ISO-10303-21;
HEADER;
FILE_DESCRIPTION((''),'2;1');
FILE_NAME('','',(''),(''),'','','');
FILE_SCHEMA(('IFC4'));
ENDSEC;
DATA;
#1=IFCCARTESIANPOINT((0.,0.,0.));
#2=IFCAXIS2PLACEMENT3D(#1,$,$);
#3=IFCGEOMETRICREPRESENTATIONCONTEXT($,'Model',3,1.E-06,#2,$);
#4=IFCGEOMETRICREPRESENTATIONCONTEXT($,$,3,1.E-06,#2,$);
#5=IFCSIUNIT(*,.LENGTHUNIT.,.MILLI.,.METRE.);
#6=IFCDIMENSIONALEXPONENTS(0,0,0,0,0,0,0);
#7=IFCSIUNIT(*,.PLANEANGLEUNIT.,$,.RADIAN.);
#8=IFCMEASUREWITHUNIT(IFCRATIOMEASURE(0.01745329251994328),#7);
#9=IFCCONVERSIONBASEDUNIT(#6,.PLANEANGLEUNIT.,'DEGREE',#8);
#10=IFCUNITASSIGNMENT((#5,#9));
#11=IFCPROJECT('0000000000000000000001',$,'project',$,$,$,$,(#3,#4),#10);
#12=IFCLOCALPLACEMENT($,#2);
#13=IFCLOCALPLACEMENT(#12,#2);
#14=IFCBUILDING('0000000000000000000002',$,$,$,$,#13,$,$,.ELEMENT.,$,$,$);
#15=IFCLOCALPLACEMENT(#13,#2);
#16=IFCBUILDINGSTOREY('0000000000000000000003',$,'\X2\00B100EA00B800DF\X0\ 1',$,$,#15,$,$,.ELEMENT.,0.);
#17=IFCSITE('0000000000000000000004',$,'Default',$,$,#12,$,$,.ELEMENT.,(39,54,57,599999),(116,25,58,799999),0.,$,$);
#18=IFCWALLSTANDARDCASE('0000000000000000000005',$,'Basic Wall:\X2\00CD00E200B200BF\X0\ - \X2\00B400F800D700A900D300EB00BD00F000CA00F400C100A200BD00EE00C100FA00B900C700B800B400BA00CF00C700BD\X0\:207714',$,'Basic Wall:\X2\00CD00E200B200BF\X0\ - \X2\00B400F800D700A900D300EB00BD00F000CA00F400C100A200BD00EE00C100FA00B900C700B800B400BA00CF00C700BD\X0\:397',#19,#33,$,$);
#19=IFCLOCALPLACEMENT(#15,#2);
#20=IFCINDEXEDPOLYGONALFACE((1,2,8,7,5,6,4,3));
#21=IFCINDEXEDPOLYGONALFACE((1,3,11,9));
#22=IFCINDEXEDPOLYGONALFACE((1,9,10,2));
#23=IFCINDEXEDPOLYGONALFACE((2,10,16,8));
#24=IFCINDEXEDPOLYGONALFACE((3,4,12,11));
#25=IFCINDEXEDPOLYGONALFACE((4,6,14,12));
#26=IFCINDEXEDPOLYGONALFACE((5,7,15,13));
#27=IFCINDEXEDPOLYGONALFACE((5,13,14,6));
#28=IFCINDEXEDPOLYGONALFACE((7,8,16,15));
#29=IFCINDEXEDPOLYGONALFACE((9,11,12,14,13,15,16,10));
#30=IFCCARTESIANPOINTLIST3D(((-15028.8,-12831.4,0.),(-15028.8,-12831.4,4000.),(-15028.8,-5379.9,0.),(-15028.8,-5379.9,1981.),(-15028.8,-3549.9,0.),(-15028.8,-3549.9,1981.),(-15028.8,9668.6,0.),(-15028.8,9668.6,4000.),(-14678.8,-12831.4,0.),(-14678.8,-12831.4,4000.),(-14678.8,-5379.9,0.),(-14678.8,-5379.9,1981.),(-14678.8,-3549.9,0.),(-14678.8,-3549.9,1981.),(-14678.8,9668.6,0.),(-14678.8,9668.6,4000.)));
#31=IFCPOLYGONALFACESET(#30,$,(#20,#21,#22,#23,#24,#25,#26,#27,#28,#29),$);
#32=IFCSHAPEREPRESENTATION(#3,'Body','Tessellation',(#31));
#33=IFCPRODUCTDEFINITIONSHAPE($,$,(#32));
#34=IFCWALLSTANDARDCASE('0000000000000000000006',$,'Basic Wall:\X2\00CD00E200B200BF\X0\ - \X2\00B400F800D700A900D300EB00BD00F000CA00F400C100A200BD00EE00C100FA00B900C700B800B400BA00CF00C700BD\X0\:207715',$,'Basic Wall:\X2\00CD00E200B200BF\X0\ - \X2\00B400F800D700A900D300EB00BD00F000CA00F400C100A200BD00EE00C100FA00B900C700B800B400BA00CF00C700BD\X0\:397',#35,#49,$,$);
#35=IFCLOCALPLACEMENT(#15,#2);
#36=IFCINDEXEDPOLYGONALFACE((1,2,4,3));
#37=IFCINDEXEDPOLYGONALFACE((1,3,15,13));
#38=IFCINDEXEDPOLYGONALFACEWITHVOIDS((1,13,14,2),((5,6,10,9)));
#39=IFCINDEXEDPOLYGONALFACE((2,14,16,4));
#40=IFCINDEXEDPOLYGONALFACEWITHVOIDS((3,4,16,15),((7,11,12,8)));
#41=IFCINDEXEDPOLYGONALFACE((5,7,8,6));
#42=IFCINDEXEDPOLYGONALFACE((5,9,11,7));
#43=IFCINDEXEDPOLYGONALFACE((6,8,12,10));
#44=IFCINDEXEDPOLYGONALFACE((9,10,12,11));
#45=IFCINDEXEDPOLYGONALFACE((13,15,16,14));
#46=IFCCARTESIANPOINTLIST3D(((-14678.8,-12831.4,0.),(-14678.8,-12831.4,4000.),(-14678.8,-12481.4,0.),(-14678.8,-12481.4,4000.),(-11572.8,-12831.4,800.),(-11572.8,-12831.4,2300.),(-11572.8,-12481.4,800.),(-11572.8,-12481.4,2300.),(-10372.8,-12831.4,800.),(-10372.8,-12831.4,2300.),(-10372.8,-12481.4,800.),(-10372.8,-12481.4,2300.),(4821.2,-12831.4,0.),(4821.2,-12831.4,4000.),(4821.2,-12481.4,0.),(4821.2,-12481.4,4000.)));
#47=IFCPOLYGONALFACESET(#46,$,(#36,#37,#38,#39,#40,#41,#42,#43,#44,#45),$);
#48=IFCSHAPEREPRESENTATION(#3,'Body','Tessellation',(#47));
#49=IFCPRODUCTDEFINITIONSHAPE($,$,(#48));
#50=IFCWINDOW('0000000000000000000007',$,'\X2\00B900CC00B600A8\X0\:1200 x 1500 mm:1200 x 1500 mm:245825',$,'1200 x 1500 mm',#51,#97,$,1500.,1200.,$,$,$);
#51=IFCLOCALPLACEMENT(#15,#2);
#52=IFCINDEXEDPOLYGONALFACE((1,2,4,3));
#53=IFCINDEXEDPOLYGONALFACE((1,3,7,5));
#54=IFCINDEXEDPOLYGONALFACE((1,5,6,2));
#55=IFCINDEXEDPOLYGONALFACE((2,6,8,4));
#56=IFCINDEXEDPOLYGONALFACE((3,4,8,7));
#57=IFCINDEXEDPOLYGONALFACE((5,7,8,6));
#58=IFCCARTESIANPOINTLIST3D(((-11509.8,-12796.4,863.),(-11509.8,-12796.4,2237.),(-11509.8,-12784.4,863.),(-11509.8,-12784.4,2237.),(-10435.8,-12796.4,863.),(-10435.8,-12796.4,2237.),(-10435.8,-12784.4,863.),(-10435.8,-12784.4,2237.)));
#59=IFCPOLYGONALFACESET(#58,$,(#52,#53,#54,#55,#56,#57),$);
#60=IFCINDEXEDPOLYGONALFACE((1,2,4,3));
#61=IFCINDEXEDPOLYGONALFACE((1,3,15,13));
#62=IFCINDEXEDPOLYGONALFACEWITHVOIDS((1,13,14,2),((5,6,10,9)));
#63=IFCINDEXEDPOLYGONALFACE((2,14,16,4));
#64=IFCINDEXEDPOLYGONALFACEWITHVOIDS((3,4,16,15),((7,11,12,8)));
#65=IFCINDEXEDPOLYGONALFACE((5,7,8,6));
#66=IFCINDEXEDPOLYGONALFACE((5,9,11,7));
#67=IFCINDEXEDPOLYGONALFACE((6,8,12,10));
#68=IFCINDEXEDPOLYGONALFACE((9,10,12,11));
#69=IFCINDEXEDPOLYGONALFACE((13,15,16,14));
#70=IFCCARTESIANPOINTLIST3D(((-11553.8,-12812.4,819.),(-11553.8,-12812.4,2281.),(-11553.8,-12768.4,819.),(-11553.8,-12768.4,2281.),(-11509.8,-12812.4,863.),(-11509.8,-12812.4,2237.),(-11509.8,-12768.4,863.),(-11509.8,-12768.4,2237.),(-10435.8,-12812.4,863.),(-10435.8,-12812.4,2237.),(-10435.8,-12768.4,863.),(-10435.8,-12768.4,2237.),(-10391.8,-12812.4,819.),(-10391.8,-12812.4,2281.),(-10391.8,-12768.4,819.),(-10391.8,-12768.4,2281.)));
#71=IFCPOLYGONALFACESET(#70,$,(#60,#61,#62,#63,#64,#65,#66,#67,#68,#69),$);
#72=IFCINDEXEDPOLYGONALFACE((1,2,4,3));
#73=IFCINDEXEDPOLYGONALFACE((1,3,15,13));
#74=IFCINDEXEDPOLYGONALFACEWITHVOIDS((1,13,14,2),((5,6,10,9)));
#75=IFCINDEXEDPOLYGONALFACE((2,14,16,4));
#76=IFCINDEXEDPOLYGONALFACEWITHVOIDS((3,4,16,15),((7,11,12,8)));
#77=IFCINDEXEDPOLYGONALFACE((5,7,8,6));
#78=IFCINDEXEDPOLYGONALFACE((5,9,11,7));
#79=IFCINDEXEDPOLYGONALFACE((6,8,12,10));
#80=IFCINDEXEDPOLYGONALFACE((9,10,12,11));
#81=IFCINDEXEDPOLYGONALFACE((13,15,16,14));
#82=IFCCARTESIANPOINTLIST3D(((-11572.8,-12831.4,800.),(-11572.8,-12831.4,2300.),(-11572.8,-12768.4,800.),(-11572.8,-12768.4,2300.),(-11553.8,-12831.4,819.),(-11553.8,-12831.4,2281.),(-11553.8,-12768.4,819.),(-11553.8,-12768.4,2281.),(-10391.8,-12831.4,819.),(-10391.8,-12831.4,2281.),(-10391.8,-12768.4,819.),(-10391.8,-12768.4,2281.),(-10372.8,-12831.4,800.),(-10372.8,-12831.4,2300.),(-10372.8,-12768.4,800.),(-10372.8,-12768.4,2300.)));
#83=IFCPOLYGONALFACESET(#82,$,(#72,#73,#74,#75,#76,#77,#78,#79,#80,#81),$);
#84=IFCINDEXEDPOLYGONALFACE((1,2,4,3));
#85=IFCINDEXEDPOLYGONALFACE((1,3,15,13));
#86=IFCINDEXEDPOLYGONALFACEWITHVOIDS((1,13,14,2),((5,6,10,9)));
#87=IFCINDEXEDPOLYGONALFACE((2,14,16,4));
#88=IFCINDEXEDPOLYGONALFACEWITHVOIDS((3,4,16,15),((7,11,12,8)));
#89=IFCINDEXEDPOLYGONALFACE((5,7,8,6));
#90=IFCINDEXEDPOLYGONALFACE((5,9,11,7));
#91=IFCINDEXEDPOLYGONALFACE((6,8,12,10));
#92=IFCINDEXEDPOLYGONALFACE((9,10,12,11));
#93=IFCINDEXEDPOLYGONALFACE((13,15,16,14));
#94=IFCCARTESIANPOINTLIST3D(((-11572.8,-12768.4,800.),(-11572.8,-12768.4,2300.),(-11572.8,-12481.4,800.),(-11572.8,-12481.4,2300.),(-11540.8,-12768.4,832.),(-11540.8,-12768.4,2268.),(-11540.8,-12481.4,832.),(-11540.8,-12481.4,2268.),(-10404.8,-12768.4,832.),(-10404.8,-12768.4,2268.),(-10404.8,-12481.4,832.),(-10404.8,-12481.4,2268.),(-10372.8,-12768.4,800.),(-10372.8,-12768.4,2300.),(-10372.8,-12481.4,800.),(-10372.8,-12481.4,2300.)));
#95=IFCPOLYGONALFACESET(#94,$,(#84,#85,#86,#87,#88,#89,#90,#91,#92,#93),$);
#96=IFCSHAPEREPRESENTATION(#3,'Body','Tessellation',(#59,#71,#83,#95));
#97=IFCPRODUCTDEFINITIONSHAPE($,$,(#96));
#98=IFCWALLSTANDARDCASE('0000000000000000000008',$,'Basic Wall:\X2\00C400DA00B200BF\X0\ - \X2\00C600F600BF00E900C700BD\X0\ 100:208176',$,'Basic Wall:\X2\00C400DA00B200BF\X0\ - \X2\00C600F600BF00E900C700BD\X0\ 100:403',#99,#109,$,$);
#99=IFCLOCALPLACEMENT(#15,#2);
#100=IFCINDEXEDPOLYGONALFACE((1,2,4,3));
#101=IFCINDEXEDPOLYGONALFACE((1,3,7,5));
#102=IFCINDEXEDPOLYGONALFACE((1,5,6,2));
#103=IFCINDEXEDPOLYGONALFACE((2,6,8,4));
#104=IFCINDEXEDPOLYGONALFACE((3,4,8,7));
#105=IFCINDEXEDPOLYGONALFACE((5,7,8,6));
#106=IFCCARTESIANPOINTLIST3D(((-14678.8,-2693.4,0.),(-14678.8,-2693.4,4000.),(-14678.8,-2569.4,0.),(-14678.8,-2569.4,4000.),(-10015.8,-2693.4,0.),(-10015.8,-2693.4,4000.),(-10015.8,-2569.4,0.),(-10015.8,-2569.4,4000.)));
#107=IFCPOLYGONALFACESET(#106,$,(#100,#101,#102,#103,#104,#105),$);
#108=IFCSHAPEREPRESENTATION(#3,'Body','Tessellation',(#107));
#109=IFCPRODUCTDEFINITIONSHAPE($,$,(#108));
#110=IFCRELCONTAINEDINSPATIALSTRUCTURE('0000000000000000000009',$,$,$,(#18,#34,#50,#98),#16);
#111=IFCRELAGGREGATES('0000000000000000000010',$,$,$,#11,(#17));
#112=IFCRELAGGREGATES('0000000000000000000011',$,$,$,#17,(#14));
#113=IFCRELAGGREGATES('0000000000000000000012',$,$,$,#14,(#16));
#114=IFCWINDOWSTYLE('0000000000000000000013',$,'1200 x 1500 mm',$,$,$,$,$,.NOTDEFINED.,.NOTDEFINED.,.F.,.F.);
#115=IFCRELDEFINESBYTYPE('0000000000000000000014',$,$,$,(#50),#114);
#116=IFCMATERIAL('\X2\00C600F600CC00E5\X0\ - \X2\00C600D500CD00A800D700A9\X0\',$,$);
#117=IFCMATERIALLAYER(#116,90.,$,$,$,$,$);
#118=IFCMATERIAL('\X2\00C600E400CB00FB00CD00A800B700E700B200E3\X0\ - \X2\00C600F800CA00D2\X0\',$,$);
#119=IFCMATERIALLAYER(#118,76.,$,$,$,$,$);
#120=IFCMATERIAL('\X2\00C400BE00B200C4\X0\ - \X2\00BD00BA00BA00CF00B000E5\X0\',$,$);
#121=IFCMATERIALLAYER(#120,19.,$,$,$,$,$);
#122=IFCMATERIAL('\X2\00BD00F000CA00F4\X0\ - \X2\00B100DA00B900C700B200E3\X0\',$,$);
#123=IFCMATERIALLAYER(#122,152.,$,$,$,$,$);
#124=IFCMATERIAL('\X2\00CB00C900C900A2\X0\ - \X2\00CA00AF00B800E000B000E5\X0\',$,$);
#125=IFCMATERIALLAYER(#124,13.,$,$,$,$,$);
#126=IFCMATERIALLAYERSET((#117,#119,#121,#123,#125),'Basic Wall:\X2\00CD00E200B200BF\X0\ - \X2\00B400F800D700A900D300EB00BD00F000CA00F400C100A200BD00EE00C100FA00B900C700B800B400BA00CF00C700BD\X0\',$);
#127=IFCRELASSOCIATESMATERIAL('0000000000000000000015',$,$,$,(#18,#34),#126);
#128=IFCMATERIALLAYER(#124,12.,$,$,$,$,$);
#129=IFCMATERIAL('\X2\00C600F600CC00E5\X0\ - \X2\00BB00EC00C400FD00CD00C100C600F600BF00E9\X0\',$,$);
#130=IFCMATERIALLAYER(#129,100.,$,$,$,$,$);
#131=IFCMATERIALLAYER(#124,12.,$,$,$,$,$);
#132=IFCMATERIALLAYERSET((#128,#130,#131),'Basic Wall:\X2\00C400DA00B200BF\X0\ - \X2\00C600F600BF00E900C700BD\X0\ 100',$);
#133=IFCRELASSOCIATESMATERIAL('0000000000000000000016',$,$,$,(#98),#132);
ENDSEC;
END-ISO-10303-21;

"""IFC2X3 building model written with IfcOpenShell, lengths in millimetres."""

from ifc_helpers import new_model, entity, si_unit, converted_unit, frame, frame_2d, origin, origin_2d_with_axis, place, context, project, spatial, polyline, rectangle, outline, extrude, source, transform, mapped, material, layer, layer_set, layer_usage, type_object, type_shapes, element, fill, save


model = new_model("IFC2X3")

# Units and contexts
model_context = context("Model", 3, precision=1e-06, world=origin())
context_of_model = context(None, 3, precision=1e-06, world=origin())
ifc_project = project(units=[si_unit("LENGTHUNIT", "METRE", prefix="MILLI"), converted_unit("PLANEANGLEUNIT", "DEGREE", entity("IfcRatioMeasure", 0.01745329251994328), si_unit("PLANEANGLEUNIT", "RADIAN"), dimensions=[0, 0, 0, 0, 0, 0, 0])], contexts=[model_context, context_of_model])

# Site, building, storey
site_placement = place(None, origin())
site = spatial("IfcSite", under=ifc_project, at=site_placement, Name="Default", CompositionType="ELEMENT", RefLatitude=(39, 54, 57, 599999), RefLongitude=(116, 25, 58, 799999), RefElevation=0.0)
building_placement = place(site_placement, origin())
building = spatial("IfcBuilding", under=site, at=building_placement, CompositionType="ELEMENT")
storey_placement = place(building_placement, origin())
storey = spatial("IfcBuildingStorey", under=building, at=storey_placement, Name="±ê¸ß 1", CompositionType="ELEMENT", Elevation=0.0)

# Wall, opening
ifc_material_1 = material(Name="ÆöÌå - ÆÕÍ¨×©")
ifc_layer_1 = layer(ifc_material_1, 90.0)
ifc_material_2 = material(Name="ÆäËûÍ¨·ç²ã - ÆøÊÒ")
ifc_layer_2 = layer(ifc_material_2, 76.0)
ifc_material_3 = material(Name="Ä¾²Ä - ½ººÏ°å")
ifc_layer_3 = layer(ifc_material_3, 19.0)
ifc_material_4 = material(Name="½ðÊô - ±Ú¹Ç²ã")
ifc_layer_4 = layer(ifc_material_4, 152.0)
ifc_material_5 = material(Name="ËÉÉ¢ - Ê¯¸à°å")
ifc_layer_5 = layer(ifc_material_5, 13.0)
ifc_layer_set_1 = layer_set([ifc_layer_1, ifc_layer_2, ifc_layer_3, ifc_layer_4, ifc_layer_5], Name="Basic Wall:Íâ²¿ - ´ø×©Óë½ðÊôÁ¢½îÁú¹Ç¸´ºÏÇ½")
ifc_layer_usage_1 = layer_usage(ifc_layer_set_1, "AXIS2", "NEGATIVE", 175.0)
wall_1_placement = place(storey_placement, frame((-14853.8, -12831.4, 0.0), z_axis=(0.0, 0.0, 1.0), x_axis=(0.0, 1.0, 0.0)))
wall_1 = element("IfcWallStandardCase", 1, at=wall_1_placement, inside=storey, material=ifc_layer_usage_1, Name="Basic Wall:Íâ²¿ - ´ø×©Óë½ðÊôÁ¢½îÁú¹Ç¸´ºÏÇ½:207714", ObjectType="Basic Wall:Íâ²¿ - ´ø×©Óë½ðÊôÁ¢½îÁú¹Ç¸´ºÏÇ½:397", context=model_context, shape_type="SweptSolid", body=[
    extrude(rectangle(XDim=22500.0, YDim=350.0, at=frame_2d((11250.0, 0.0), x_axis=(-1.0, 0.0))), origin(), (0.0, 0.0, 1.0), 4000.0),
])
opening_1_placement = place(wall_1_placement, frame((9281.5, 175.0, 0.0)))
element("IfcOpeningElement", 2, at=opening_1_placement, cuts=wall_1, ObjectType="Opening", context=model_context, shape_type="SweptSolid", body=[
    extrude(rectangle(XDim=1981.0, YDim=1830.0, at=frame_2d((990.5, 915.0), x_axis=(1.0, 0.0))), frame((0.0, 0.0, 0.0), z_axis=(0.0, -1.0, 0.0), x_axis=(0.0, 0.0, 1.0)), (0.0, 0.0, 1.0), 350.0),
])

# Wall, opening, window
ifc_layer_usage_2 = layer_usage(ifc_layer_set_1, "AXIS2", "NEGATIVE", 175.0)
wall_2_placement = place(storey_placement, frame((4821.2, -12656.4, 0.0), z_axis=(0.0, 0.0, 1.0), x_axis=(-1.0, 0.0, 0.0)))
wall_2 = element("IfcWallStandardCase", 3, at=wall_2_placement, inside=storey, material=ifc_layer_usage_2, Name="Basic Wall:Íâ²¿ - ´ø×©Óë½ðÊôÁ¢½îÁú¹Ç¸´ºÏÇ½:207715", ObjectType="Basic Wall:Íâ²¿ - ´ø×©Óë½ðÊôÁ¢½îÁú¹Ç¸´ºÏÇ½:397", context=model_context, shape_type="SweptSolid", body=[
    extrude(rectangle(XDim=19500.0, YDim=350.0, at=frame_2d((9750.0, 0.0), x_axis=(-1.0, 0.0))), origin(), (0.0, 0.0, 1.0), 4000.0),
])
opening_2_placement = place(wall_2_placement, frame((15194.0, -175.0, 800.0)))
opening_2 = element("IfcOpeningElement", 4, at=opening_2_placement, cuts=wall_2, ObjectType="Opening", context=model_context, shape_type="SweptSolid", body=[
    extrude(rectangle(XDim=1500.0, YDim=1200.0, at=frame_2d((750.0, 600.0), x_axis=(1.0, 0.0))), frame((0.0, 0.0, 0.0), z_axis=(0.0, 1.0, 0.0), x_axis=(0.0, 0.0, 1.0)), (0.0, 0.0, 1.0), 350.0),
])
window_style_1 = type_object("IfcWindowStyle", Name="1200 x 1500 mm", ConstructionType="NOTDEFINED", OperationType="NOTDEFINED", ParameterTakesPrecedence=False, Sizeable=False)
shared_shape_1 = source(origin(), model_context, "Body", "SweptSolid", [
    extrude(rectangle(XDim=12.0, YDim=1074.0, at=origin_2d_with_axis()), frame((600.0, 309.0, 63.0), z_axis=(0.0, 0.0, 1.0), x_axis=(0.0, -1.0, 0.0)), (0.0, 0.0, 1.0), 1374.0),
    extrude(outline(polyline([(-581.0, -731.0), (581.0, -731.0), (581.0, 731.0), (-581.0, 731.0), (-581.0, -731.0)]), holes=[polyline([(-537.0, -687.0), (-537.0, 687.0), (537.0, 687.0), (537.0, -687.0), (-537.0, -687.0)])]), frame((600.0, 287.0, 750.0), z_axis=(0.0, 1.0, 0.0), x_axis=(1.0, 0.0, 0.0)), (0.0, 0.0, 1.0), 44.0),
    extrude(outline(polyline([(-600.0, -750.0), (600.0, -750.0), (600.0, 750.0), (-600.0, 750.0), (-600.0, -750.0)]), holes=[polyline([(-581.0, -731.0), (-581.0, 731.0), (581.0, 731.0), (581.0, -731.0), (-581.0, -731.0)])]), frame((600.0, 287.0, 750.0), z_axis=(0.0, 1.0, 0.0), x_axis=(1.0, 0.0, 0.0)), (0.0, 0.0, 1.0), 63.0),
    extrude(outline(polyline([(-600.0, -750.0), (600.0, -750.0), (600.0, 750.0), (-600.0, 750.0), (-600.0, -750.0)]), holes=[polyline([(-568.0, -718.0), (-568.0, 718.0), (568.0, 718.0), (568.0, -718.0), (-568.0, -718.0)])]), frame((600.0, 0.0, 750.0), z_axis=(0.0, 1.0, 0.0), x_axis=(1.0, 0.0, 0.0)), (0.0, 0.0, 1.0), 287.0),
])
type_shapes(window_style_1, [shared_shape_1])
window_1_placement = place(opening_2_placement, origin())
window_1 = element("IfcWindow", 5, at=window_1_placement, inside=storey, type_object=window_style_1, Name="¹Ì¶¨:1200 x 1500 mm:1200 x 1500 mm:245825", ObjectType="1200 x 1500 mm", OverallHeight=1500.0, OverallWidth=1200.0, context=model_context, shape_type="MappedRepresentation", body=[
    mapped(shared_shape_1, transform((0.0, 0.0, 0.0), scale=1.0)),
])
fill(opening_2, window_1)

# Wall
ifc_layer_6 = layer(ifc_material_5, 12.0)
ifc_material_6 = material(Name="ÆöÌå - »ìÄýÍÁÆö¿é")
ifc_layer_7 = layer(ifc_material_6, 100.0)
ifc_layer_8 = layer(ifc_material_5, 12.0)
ifc_layer_set_2 = layer_set([ifc_layer_6, ifc_layer_7, ifc_layer_8], Name="Basic Wall:ÄÚ²¿ - Æö¿éÇ½ 100")
ifc_layer_usage_3 = layer_usage(ifc_layer_set_2, "AXIS2", "NEGATIVE", 62.0)
wall_3_placement = place(storey_placement, frame((-10015.8, -2631.4, 0.0), z_axis=(0.0, 0.0, 1.0), x_axis=(-1.0, 0.0, 0.0)))
element("IfcWallStandardCase", 6, at=wall_3_placement, inside=storey, material=ifc_layer_usage_3, Name="Basic Wall:ÄÚ²¿ - Æö¿éÇ½ 100:208176", ObjectType="Basic Wall:ÄÚ²¿ - Æö¿éÇ½ 100:403", context=model_context, shape_type="SweptSolid", body=[
    extrude(rectangle(XDim=4663.0, YDim=124.0, at=frame_2d((2331.5, 0.0), x_axis=(-1.0, 0.0))), origin(), (0.0, 0.0, 1.0), 4000.0),
])

save(model, "model.ifc")
